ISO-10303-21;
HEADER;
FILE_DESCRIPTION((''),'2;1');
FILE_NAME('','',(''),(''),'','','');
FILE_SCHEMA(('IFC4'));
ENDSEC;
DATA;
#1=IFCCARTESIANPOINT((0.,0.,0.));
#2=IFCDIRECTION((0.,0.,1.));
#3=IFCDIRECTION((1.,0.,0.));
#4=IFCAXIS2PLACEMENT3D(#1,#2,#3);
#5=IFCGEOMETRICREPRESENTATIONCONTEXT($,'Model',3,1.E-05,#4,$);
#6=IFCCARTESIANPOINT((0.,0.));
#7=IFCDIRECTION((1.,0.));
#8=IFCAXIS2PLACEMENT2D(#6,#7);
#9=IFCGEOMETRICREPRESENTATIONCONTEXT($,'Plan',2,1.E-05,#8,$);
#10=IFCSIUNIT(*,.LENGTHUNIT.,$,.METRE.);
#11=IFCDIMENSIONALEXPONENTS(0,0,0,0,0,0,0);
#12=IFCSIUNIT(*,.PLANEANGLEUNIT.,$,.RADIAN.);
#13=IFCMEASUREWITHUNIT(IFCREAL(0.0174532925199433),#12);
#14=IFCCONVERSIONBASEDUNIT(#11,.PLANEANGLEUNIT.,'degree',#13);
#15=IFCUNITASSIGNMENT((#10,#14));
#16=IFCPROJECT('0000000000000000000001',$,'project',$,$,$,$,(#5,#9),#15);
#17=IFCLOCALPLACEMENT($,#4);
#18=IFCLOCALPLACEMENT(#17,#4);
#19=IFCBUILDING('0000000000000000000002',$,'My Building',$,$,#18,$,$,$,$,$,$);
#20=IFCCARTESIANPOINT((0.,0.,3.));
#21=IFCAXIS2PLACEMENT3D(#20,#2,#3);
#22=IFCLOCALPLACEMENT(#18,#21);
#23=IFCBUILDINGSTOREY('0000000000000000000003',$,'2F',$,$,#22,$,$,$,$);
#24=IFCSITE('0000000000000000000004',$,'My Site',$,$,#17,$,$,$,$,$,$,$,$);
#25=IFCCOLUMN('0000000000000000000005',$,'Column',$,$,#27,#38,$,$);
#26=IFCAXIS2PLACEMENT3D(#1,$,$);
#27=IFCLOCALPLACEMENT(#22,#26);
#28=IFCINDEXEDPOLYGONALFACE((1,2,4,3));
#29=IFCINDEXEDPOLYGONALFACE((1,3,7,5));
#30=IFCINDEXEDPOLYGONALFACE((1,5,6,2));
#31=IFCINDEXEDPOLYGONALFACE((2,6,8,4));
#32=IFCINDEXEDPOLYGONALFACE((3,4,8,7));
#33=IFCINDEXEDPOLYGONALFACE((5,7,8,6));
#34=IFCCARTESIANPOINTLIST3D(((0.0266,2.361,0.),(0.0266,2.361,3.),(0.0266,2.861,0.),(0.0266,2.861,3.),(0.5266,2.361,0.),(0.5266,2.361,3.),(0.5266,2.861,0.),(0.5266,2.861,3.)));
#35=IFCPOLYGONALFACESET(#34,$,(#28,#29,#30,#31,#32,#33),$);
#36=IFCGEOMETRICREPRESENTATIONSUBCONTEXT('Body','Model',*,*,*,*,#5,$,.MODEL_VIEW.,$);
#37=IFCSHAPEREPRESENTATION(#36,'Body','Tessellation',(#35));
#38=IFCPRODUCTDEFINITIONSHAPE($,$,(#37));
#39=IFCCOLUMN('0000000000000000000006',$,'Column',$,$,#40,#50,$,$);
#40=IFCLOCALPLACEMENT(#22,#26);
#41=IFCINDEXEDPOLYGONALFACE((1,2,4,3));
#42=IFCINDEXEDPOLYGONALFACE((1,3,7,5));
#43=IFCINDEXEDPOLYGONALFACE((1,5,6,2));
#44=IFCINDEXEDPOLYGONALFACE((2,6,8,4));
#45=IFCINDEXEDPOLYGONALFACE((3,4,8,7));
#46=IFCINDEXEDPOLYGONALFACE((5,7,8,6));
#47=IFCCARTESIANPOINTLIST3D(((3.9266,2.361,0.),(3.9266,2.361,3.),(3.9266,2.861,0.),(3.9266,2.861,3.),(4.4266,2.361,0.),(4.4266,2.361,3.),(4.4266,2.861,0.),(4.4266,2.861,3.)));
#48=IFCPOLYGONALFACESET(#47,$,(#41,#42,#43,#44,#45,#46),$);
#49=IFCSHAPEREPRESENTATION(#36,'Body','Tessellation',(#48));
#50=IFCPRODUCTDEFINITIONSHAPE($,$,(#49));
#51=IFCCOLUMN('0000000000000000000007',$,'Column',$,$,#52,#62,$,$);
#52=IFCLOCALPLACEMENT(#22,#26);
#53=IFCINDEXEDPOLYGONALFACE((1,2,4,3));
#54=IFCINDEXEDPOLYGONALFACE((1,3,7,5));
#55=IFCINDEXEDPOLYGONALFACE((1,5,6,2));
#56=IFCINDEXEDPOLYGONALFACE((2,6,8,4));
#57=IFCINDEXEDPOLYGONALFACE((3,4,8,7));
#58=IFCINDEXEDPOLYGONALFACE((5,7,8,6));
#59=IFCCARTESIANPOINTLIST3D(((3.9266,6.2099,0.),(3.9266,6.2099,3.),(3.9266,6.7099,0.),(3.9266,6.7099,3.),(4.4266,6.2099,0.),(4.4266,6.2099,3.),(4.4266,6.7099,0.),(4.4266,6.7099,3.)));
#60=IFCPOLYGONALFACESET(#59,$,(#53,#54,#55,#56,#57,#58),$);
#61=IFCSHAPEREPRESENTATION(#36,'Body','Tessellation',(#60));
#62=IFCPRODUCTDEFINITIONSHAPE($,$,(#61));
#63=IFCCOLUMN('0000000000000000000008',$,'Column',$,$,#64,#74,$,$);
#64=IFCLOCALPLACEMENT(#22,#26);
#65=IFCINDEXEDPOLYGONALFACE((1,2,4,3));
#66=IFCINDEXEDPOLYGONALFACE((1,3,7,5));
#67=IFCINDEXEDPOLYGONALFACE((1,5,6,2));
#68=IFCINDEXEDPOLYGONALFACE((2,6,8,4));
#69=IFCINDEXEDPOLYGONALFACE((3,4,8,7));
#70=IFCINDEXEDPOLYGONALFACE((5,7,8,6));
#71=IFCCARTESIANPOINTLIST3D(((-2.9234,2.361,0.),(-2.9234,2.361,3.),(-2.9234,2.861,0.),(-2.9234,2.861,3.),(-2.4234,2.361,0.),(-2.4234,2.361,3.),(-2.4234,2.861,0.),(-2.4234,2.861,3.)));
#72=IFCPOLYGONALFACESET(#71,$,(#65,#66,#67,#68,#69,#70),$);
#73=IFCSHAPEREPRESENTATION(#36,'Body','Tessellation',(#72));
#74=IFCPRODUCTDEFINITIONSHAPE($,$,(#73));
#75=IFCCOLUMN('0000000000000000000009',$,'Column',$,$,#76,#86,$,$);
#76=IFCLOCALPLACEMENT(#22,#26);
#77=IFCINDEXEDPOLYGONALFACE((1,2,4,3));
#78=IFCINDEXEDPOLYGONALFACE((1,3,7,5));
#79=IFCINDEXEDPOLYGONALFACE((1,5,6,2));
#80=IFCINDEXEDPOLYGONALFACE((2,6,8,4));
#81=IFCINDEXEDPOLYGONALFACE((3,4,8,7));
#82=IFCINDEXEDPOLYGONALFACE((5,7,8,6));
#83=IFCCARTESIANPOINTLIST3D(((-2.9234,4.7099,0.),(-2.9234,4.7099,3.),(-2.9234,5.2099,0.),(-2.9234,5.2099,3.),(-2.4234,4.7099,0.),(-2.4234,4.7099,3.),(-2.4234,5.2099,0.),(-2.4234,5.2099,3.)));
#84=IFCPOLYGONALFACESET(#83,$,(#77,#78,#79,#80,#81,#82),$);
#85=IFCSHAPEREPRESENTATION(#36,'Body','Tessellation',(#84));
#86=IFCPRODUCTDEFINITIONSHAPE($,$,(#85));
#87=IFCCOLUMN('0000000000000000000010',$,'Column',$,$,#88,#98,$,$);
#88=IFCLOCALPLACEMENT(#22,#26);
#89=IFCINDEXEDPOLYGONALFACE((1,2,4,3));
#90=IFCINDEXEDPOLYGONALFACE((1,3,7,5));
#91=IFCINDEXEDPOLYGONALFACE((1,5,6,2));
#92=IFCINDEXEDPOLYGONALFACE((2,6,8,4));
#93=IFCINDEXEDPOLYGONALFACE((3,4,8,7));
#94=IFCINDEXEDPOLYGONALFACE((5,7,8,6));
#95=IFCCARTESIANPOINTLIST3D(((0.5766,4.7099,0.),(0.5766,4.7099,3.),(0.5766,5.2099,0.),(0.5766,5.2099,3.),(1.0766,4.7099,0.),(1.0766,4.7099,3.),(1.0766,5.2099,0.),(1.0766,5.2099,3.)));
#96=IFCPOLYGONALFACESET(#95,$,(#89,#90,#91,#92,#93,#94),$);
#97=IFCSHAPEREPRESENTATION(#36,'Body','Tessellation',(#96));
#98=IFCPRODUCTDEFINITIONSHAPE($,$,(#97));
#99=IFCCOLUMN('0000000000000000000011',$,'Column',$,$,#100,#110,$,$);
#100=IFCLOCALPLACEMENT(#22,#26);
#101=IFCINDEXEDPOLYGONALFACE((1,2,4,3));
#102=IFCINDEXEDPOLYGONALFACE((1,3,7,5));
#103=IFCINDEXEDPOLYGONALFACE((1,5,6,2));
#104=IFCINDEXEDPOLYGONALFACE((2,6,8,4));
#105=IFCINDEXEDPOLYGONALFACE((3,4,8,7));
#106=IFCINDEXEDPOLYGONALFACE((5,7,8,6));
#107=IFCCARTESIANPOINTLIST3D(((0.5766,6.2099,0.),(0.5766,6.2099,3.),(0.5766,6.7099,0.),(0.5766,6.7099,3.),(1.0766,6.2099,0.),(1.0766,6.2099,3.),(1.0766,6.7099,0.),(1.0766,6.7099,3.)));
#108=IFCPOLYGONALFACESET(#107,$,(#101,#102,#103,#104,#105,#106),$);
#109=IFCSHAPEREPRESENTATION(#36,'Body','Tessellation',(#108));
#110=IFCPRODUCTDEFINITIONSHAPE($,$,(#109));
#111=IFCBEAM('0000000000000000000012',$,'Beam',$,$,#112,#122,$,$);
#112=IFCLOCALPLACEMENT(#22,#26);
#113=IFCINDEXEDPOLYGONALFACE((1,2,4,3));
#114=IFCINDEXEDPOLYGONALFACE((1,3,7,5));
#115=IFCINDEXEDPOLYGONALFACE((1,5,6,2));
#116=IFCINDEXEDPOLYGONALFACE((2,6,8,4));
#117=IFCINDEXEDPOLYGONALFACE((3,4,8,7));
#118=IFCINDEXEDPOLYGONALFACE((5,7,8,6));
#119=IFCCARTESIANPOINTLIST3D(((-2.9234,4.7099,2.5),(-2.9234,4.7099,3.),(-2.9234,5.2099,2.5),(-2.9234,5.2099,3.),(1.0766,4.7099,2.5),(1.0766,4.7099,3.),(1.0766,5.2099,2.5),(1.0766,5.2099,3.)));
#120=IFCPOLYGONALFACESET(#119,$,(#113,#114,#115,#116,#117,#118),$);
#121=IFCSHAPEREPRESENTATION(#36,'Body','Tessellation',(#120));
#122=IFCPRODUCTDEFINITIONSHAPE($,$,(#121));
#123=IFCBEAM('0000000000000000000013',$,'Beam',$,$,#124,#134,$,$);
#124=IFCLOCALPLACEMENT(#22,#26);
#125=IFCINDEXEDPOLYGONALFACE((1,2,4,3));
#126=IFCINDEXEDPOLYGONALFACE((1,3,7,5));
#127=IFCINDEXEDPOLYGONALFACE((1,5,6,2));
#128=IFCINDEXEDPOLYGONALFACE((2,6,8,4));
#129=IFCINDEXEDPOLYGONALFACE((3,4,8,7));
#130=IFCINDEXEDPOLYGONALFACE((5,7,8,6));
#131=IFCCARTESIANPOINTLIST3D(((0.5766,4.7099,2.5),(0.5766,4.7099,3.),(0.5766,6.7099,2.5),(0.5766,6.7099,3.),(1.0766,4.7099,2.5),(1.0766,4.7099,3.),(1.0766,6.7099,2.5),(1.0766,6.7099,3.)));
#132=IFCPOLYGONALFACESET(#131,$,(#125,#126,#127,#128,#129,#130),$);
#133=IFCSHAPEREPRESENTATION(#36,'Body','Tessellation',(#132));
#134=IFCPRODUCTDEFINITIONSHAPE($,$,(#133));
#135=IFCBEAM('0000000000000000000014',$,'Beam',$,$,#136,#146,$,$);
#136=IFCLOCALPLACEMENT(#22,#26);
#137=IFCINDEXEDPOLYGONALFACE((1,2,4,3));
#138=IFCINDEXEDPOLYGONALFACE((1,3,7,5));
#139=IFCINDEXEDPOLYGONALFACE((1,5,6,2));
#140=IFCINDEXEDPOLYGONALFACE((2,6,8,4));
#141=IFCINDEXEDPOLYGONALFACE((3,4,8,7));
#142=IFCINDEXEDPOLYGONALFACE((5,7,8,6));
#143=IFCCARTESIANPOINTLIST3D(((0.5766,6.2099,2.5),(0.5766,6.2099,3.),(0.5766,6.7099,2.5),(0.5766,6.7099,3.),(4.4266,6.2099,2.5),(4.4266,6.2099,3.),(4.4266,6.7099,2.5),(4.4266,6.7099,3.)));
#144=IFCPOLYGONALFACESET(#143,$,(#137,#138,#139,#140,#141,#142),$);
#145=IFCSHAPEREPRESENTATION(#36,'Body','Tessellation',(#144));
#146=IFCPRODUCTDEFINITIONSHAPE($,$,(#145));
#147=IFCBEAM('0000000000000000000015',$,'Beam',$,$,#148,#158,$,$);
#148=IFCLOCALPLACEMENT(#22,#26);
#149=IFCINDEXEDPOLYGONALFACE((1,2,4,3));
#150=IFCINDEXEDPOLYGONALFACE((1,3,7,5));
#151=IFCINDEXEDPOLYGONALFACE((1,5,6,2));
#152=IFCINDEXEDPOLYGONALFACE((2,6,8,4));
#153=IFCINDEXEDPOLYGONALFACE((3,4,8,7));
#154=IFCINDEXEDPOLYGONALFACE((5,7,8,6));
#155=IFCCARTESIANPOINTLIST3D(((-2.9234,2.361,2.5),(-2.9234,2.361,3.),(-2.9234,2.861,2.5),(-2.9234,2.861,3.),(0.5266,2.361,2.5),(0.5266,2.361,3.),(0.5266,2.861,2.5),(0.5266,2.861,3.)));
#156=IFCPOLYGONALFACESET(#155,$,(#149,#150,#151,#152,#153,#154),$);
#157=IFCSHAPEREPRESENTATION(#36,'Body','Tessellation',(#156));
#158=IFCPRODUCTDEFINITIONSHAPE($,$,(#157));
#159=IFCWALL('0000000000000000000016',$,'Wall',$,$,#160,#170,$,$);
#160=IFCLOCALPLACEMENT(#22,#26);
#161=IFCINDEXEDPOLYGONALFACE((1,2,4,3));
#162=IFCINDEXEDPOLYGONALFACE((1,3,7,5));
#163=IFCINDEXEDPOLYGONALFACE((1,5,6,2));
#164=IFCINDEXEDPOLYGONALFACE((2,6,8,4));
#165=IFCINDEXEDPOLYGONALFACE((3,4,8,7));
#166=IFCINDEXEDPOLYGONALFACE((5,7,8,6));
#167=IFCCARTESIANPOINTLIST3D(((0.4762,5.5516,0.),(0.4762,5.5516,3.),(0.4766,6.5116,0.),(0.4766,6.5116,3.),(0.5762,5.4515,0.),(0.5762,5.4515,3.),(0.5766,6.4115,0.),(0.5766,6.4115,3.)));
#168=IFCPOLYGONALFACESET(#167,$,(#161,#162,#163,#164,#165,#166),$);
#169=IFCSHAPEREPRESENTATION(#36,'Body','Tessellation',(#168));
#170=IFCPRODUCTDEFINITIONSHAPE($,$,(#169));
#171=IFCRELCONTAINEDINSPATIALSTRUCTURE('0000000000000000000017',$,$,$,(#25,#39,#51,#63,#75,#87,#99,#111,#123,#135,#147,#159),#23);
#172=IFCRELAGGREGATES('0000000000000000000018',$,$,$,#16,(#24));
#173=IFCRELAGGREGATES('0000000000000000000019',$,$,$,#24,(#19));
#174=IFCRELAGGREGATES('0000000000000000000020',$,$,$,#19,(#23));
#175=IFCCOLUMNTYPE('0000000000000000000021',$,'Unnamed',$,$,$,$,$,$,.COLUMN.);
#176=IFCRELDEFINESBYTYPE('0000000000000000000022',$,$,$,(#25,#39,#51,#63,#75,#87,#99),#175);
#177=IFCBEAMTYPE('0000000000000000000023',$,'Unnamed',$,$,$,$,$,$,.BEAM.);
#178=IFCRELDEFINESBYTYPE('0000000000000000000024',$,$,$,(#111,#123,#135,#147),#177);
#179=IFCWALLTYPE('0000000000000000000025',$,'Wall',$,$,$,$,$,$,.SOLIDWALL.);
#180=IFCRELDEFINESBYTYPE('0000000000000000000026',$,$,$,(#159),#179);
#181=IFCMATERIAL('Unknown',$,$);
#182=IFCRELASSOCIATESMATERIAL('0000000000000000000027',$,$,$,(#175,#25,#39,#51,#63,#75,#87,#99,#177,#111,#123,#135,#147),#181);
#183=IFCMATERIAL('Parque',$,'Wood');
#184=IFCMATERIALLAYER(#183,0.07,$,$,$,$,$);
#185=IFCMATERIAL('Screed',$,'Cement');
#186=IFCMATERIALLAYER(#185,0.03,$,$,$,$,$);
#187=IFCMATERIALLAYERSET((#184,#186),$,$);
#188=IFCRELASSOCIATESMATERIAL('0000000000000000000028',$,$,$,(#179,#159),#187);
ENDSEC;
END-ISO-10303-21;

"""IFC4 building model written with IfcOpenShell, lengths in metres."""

from ifc_helpers import new_model, entity, si_unit, converted_unit, frame, origin_with_axes, origin_2d_with_axis, place, context, subcontext, project, spatial, line, indexed_curve, rectangle, outline, extrude, material, layer, layer_set, layer_usage, material_profile, profile_set, profile_usage, type_object, element, save


model = new_model("IFC4")

# Units and contexts
model_context = context("Model", 3, precision=1e-05, world=origin_with_axes())
plan_context = context("Plan", 2, precision=1e-05, world=origin_2d_with_axis())
body_context_1 = subcontext(model_context, "Body", "Model", "MODEL_VIEW")
ifc_project = project(units=[si_unit("LENGTHUNIT", "METRE"), converted_unit("PLANEANGLEUNIT", "degree", entity("IfcReal", 0.0174532925199433), si_unit("PLANEANGLEUNIT", "RADIAN"), dimensions=[0, 0, 0, 0, 0, 0, 0])], contexts=[model_context, plan_context])

# Site, building, storey
site_placement = place(None, origin_with_axes())
site = spatial("IfcSite", under=ifc_project, at=site_placement, Name="My Site")
building_placement = place(site_placement, origin_with_axes())
building = spatial("IfcBuilding", under=site, at=building_placement, Name="My Building")
storey_placement = place(building_placement, frame((0.0, 0.0, 3.0), z_axis=(0.0, 0.0, 1.0), x_axis=(1.0, 0.0, 0.0)))
storey = spatial("IfcBuildingStorey", under=building, at=storey_placement, Name="2F")

# Columns
ifc_material_1 = material(Name="Unknown")
ifc_material_profile_1 = material_profile(ifc_material_1, rectangle(XDim=0.5, YDim=0.5))
ifc_profile_set_1 = profile_set([ifc_material_profile_1])
ifc_profile_usage_1 = profile_usage(ifc_profile_set_1, cardinal=7)
column_type = type_object("IfcColumnType", Name="Unnamed", PredefinedType="COLUMN", material=ifc_profile_set_1)
column_1_placement = place(storey_placement, frame((0.5266, 2.861, 0.0), z_axis=(0.0, 0.0, 1.0), x_axis=(1.0, 0.0, 0.0)))
element("IfcColumn", 1, at=column_1_placement, inside=storey, type_object=column_type, material=ifc_profile_usage_1, Name="Column", context=body_context_1, shape_type="SweptSolid", body=[
    extrude(rectangle(XDim=0.5, YDim=0.5), frame((-0.25, -0.25, 0.0), z_axis=(0.0, 0.0, 1.0), x_axis=(1.0, 0.0, 0.0)), (0.0, 0.0, 1.0), 3.0),
])
ifc_profile_usage_2 = profile_usage(ifc_profile_set_1, cardinal=5)
column_2_placement = place(storey_placement, frame((4.1766, 2.611, 0.0), z_axis=(0.0, 0.0, 1.0), x_axis=(1.0, 0.0, 0.0)))
element("IfcColumn", 2, at=column_2_placement, inside=storey, type_object=column_type, material=ifc_profile_usage_2, Name="Column", context=body_context_1, shape_type="SweptSolid", body=[
    extrude(rectangle(XDim=0.5, YDim=0.5), origin_with_axes(), (0.0, 0.0, 1.0), 3.0),
])
ifc_profile_usage_3 = profile_usage(ifc_profile_set_1, cardinal=5)
column_3_placement = place(storey_placement, frame((4.1766, 6.4599, 0.0), z_axis=(0.0, 0.0, 1.0), x_axis=(1.0, 0.0, 0.0)))
element("IfcColumn", 3, at=column_3_placement, inside=storey, type_object=column_type, material=ifc_profile_usage_3, Name="Column", context=body_context_1, shape_type="SweptSolid", body=[
    extrude(rectangle(XDim=0.5, YDim=0.5), origin_with_axes(), (0.0, 0.0, 1.0), 3.0),
])
ifc_profile_usage_4 = profile_usage(ifc_profile_set_1, cardinal=5)
column_4_placement = place(storey_placement, frame((-2.6734, 2.611, 0.0), z_axis=(0.0, 0.0, 1.0), x_axis=(1.0, 0.0, 0.0)))
element("IfcColumn", 4, at=column_4_placement, inside=storey, type_object=column_type, material=ifc_profile_usage_4, Name="Column", context=body_context_1, shape_type="SweptSolid", body=[
    extrude(rectangle(XDim=0.5, YDim=0.5), origin_with_axes(), (0.0, 0.0, 1.0), 3.0),
])
ifc_profile_usage_5 = profile_usage(ifc_profile_set_1, cardinal=5)
column_5_placement = place(storey_placement, frame((-2.6734, 4.9599, 0.0), z_axis=(0.0, 0.0, 1.0), x_axis=(1.0, 0.0, 0.0)))
element("IfcColumn", 5, at=column_5_placement, inside=storey, type_object=column_type, material=ifc_profile_usage_5, Name="Column", context=body_context_1, shape_type="SweptSolid", body=[
    extrude(rectangle(XDim=0.5, YDim=0.5), origin_with_axes(), (0.0, 0.0, 1.0), 3.0),
])
ifc_profile_usage_6 = profile_usage(ifc_profile_set_1, cardinal=5)
column_6_placement = place(storey_placement, frame((0.8266, 4.9599, 0.0), z_axis=(0.0, 0.0, 1.0), x_axis=(1.0, 0.0, 0.0)))
element("IfcColumn", 6, at=column_6_placement, inside=storey, type_object=column_type, material=ifc_profile_usage_6, Name="Column", context=body_context_1, shape_type="SweptSolid", body=[
    extrude(rectangle(XDim=0.5, YDim=0.5), origin_with_axes(), (0.0, 0.0, 1.0), 3.0),
])
ifc_profile_usage_7 = profile_usage(ifc_profile_set_1, cardinal=5)
column_7_placement = place(storey_placement, frame((0.8266, 6.4599, 0.0), z_axis=(0.0, 0.0, 1.0), x_axis=(1.0, 0.0, 0.0)))
element("IfcColumn", 7, at=column_7_placement, inside=storey, type_object=column_type, material=ifc_profile_usage_7, Name="Column", context=body_context_1, shape_type="SweptSolid", body=[
    extrude(rectangle(XDim=0.5, YDim=0.5), origin_with_axes(), (0.0, 0.0, 1.0), 3.0),
])

# Beams
ifc_material_profile_2 = material_profile(ifc_material_1, rectangle(XDim=0.5, YDim=0.5))
ifc_profile_set_2 = profile_set([ifc_material_profile_2])
ifc_profile_usage_8 = profile_usage(ifc_profile_set_2, cardinal=7)
beam_type = type_object("IfcBeamType", Name="Unnamed", PredefinedType="BEAM", material=ifc_profile_set_2)
beam_1_placement = place(storey_placement, frame((1.0766, 4.7099, 3.0), z_axis=(-1.0, 0.0, 0.0), x_axis=(0.0, -1.0, 0.0)))
element("IfcBeam", 8, at=beam_1_placement, inside=storey, type_object=beam_type, material=ifc_profile_usage_8, Name="Beam", context=body_context_1, shape_type="SweptSolid", body=[
    extrude(rectangle(XDim=0.5, YDim=0.5), frame((-0.25, -0.25, 0.0), z_axis=(0.0, 0.0, 1.0), x_axis=(1.0, 0.0, 0.0)), (0.0, 0.0, 1.0), 4.0),
])
ifc_profile_usage_9 = profile_usage(ifc_profile_set_2, cardinal=7)
beam_2_placement = place(storey_placement, frame((0.5766, 4.7099, 3.0), z_axis=(0.0, 1.0, 0.0), x_axis=(-1.0, 0.0, 0.0)))
element("IfcBeam", 9, at=beam_2_placement, inside=storey, type_object=beam_type, material=ifc_profile_usage_9, Name="Beam", context=body_context_1, shape_type="SweptSolid", body=[
    extrude(rectangle(XDim=0.5, YDim=0.5), frame((-0.25, -0.25, 0.0), z_axis=(0.0, 0.0, 1.0), x_axis=(1.0, 0.0, 0.0)), (0.0, 0.0, 1.0), 2.0),
])
ifc_profile_usage_10 = profile_usage(ifc_profile_set_2, cardinal=7)
beam_3_placement = place(storey_placement, frame((0.5766, 6.7099, 3.0), z_axis=(1.0, 0.0, 0.0), x_axis=(0.0, 1.0, 0.0)))
element("IfcBeam", 10, at=beam_3_placement, inside=storey, type_object=beam_type, material=ifc_profile_usage_10, Name="Beam", context=body_context_1, shape_type="SweptSolid", body=[
    extrude(rectangle(XDim=0.5, YDim=0.5), frame((-0.25, -0.25, 0.0), z_axis=(0.0, 0.0, 1.0), x_axis=(1.0, 0.0, 0.0)), (0.0, 0.0, 1.0), 3.85),
])
ifc_profile_usage_11 = profile_usage(ifc_profile_set_2, cardinal=7)
beam_4_placement = place(storey_placement, frame((-2.9234, 2.861, 3.0), z_axis=(1.0, -0.000001, 0.0), x_axis=(0.000001, 1.0, 0.0)))
element("IfcBeam", 11, at=beam_4_placement, inside=storey, type_object=beam_type, material=ifc_profile_usage_11, Name="Beam", context=body_context_1, shape_type="SweptSolid", body=[
    extrude(rectangle(XDim=0.5, YDim=0.5), frame((-0.25, -0.25, 0.0), z_axis=(0.0, 0.0, 1.0), x_axis=(1.0, 0.0, 0.0)), (0.0, 0.0, 1.0), 3.45),
])

# Wall
ifc_material_2 = material(Name="Parque", Category="Wood")
ifc_layer_1 = layer(ifc_material_2, 0.07)
ifc_material_3 = material(Name="Screed", Category="Cement")
ifc_layer_2 = layer(ifc_material_3, 0.03)
ifc_layer_set = layer_set([ifc_layer_1, ifc_layer_2])
ifc_layer_usage_1 = layer_usage(ifc_layer_set, "AXIS2", "POSITIVE", 0.0)
wall_type = type_object("IfcWallType", Name="Wall", PredefinedType="SOLIDWALL", material=ifc_layer_set)
wall_1_placement = place(storey_placement, frame((0.4766, 6.5116, 0.0), z_axis=(0.0, 0.0, 1.0), x_axis=(-0.000415, -1.0, 0.0)))
element("IfcWall", 12, at=wall_1_placement, inside=storey, type_object=wall_type, material=ifc_layer_usage_1, Name="Wall", context=body_context_1, shape_type="SweptSolid", body=[
    extrude(outline(indexed_curve([(0.0, 0.0), (0.1, 0.1), (1.06, 0.1), (0.96, 0.0)], segments=[line(1, 2, 3, 4, 1)])), origin_with_axes(), (0.0, 0.0, 1.0), 3.0),
])

save(model, "model.ifc")
